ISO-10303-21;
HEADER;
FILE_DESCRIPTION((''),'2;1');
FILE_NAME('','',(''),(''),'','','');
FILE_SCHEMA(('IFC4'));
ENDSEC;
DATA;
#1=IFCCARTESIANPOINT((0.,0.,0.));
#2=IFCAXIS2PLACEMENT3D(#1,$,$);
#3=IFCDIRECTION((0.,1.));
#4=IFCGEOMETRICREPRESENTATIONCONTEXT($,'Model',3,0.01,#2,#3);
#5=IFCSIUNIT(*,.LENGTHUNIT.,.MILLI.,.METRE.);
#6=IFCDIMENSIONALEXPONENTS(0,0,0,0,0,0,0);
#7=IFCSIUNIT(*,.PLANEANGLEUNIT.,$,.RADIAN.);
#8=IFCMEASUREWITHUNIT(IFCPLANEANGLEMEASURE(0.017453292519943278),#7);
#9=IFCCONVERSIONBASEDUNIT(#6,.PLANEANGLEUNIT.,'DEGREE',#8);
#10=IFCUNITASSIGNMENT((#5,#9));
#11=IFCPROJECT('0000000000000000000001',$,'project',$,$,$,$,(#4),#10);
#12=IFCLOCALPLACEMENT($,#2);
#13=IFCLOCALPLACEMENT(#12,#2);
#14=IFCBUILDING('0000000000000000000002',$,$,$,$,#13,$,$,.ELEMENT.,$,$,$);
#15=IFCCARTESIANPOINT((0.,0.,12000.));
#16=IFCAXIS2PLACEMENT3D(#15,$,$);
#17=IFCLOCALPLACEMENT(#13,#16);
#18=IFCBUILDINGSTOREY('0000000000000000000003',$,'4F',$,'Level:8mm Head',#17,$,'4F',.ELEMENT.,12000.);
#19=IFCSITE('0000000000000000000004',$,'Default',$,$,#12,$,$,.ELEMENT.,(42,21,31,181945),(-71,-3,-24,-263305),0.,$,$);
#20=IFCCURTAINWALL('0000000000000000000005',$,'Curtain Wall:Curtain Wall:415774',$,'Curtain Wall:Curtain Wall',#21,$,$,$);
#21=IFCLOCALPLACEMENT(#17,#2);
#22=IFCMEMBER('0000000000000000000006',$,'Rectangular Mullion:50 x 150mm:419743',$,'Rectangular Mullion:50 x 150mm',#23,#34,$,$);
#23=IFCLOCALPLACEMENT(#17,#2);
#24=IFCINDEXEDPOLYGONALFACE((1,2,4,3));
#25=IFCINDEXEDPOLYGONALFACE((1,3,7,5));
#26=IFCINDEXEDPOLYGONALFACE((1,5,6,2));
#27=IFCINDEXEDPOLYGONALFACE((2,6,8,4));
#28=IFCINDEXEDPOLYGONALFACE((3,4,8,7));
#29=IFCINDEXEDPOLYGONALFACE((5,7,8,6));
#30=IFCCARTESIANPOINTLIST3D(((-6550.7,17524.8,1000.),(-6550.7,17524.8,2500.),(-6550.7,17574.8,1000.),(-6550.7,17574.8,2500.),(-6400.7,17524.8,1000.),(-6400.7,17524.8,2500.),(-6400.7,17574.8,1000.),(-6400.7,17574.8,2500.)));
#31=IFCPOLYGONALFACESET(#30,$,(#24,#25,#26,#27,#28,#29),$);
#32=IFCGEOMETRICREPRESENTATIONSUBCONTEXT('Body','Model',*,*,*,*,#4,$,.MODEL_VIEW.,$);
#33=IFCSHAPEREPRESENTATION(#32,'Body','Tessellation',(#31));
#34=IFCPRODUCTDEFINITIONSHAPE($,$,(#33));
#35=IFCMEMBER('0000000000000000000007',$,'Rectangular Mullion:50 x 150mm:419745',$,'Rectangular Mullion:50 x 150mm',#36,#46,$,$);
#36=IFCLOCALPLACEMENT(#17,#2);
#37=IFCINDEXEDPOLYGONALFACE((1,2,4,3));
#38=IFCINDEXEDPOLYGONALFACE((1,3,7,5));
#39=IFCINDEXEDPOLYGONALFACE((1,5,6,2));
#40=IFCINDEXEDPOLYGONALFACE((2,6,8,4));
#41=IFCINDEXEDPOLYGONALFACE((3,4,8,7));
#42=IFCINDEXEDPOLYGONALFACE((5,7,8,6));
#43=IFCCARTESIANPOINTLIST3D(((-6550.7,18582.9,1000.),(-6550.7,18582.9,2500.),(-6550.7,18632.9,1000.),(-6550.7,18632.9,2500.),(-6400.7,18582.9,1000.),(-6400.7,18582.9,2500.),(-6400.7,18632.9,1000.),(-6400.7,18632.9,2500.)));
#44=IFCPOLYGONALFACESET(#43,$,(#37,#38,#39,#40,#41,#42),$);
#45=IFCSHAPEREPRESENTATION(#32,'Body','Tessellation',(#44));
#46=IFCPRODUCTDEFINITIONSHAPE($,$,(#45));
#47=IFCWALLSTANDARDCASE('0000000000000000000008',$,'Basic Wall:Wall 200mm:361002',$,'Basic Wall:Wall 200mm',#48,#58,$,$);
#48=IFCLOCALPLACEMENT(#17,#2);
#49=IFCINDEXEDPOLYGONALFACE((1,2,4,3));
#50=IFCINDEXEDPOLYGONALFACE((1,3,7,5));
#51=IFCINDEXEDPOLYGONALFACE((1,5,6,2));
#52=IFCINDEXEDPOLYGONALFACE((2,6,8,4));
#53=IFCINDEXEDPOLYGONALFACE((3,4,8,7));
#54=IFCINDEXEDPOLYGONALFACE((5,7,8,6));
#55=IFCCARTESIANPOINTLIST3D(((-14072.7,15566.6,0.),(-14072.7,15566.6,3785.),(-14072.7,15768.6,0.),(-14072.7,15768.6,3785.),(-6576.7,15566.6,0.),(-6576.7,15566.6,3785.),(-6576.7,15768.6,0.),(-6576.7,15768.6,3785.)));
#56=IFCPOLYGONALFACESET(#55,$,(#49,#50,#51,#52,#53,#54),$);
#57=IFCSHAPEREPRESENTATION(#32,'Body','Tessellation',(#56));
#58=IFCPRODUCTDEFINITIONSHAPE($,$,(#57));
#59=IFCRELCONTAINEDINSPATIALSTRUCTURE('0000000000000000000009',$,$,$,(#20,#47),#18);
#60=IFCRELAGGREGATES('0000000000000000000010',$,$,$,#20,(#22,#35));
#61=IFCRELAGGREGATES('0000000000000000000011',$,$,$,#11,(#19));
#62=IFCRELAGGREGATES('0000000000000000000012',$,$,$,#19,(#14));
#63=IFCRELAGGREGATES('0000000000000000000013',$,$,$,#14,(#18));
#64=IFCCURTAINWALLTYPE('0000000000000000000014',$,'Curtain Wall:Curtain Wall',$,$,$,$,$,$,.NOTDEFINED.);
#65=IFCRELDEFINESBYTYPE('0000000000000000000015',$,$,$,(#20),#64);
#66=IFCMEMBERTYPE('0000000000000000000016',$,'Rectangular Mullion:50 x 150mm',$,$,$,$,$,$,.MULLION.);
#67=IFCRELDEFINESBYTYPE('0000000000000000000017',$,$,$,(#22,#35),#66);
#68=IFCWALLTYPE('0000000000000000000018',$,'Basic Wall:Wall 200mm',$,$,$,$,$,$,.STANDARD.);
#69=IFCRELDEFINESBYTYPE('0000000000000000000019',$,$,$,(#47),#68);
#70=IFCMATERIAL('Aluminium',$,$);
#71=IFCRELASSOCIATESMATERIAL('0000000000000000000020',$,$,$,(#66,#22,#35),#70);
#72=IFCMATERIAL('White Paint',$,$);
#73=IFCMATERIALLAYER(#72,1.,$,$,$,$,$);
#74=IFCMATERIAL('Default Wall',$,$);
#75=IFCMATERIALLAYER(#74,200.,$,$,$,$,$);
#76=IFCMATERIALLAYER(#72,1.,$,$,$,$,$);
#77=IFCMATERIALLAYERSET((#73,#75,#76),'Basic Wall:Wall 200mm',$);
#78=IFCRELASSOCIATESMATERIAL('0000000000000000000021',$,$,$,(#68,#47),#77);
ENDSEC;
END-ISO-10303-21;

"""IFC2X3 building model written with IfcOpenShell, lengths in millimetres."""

from ifc_helpers import new_model, entity, si_unit, converted_unit, direction, frame, frame_2d, origin, origin_2d_with_axis, place, context, subcontext, project, spatial, polyline, rectangle, extrude, clip, bounded_halfspace, source, transform, mapped, material, layer, layer_set, layer_usage, type_object, type_shapes, element, aggregate, save


model = new_model("IFC2X3")

# Units and contexts
model_context = context("Model", 3, precision=0.01, world=origin(), true_north=direction((0.0, 1.0)))
body_context = subcontext(model_context, "Body", "Model", "MODEL_VIEW")
ifc_project = project(units=[si_unit("LENGTHUNIT", "METRE", prefix="MILLI"), converted_unit("PLANEANGLEUNIT", "DEGREE", entity("IfcPlaneAngleMeasure", 0.017453292519943278), si_unit("PLANEANGLEUNIT", "RADIAN"), dimensions=[0, 0, 0, 0, 0, 0, 0])], contexts=[model_context])

# Site, building, storey
site_placement = place(None, origin())
site = spatial("IfcSite", under=ifc_project, at=site_placement, Name="Default", CompositionType="ELEMENT", RefLatitude=(42, 21, 31, 181945), RefLongitude=(-71, -3, -24, -263305), RefElevation=0.0)
building_placement = place(site_placement, origin())
building = spatial("IfcBuilding", under=site, at=building_placement, CompositionType="ELEMENT")
storey_placement = place(building_placement, frame((0.0, 0.0, 12000.0)))
storey = spatial("IfcBuildingStorey", under=building, at=storey_placement, Name="4F", ObjectType="Level:8mm Head", LongName="4F", CompositionType="ELEMENT", Elevation=12000.0)

# Curtain wall, members
curtain_wall_type = type_object("IfcCurtainWallType", Name="Curtain Wall:Curtain Wall", PredefinedType="NOTDEFINED")
curtain_wall_placement = place(storey_placement, frame((0.0, 0.0, -12000.0)))
curtain_wall = element("IfcCurtainWall", 1, at=curtain_wall_placement, inside=storey, type_object=curtain_wall_type, Name="Curtain Wall:Curtain Wall:415774", ObjectType="Curtain Wall:Curtain Wall")
ifc_material_1 = material(Name="Aluminium")
member_type_1 = type_object("IfcMemberType", Name="Rectangular Mullion:50 x 150mm", PredefinedType="MULLION", material=ifc_material_1)
shared_shape_1 = source(origin(), body_context, "Body", "SweptSolid", [
    extrude(rectangle(XDim=50.0, YDim=150.0, at=origin_2d_with_axis()), frame((0.0, 0.0, -1500.0), z_axis=(0.0, 0.0, 1.0), x_axis=(-1.0, 0.0, 0.0)), (0.0, 0.0, 1.0), 1500.0),
])
type_shapes(member_type_1, [shared_shape_1])
member_1_placement = place(curtain_wall_placement, frame((-6475.7, 17549.8, 13000.0), z_axis=(0.0, 0.0, -1.0), x_axis=(0.0, -1.0, 0.0)))
member_1 = element("IfcMember", 2, at=member_1_placement, type_object=member_type_1, material=ifc_material_1, Name="Rectangular Mullion:50 x 150mm:419743", ObjectType="Rectangular Mullion:50 x 150mm", context=body_context, shape_type="MappedRepresentation", body=[
    mapped(shared_shape_1, transform((0.0, 0.0, 0.0), scale=1.0)),
])
member_2_placement = place(curtain_wall_placement, frame((-6475.7, 18607.9, 13000.0), z_axis=(0.0, 0.0, -1.0), x_axis=(0.0, -1.0, 0.0)))
member_2 = element("IfcMember", 3, at=member_2_placement, type_object=member_type_1, material=ifc_material_1, Name="Rectangular Mullion:50 x 150mm:419745", ObjectType="Rectangular Mullion:50 x 150mm", context=body_context, shape_type="MappedRepresentation", body=[
    mapped(shared_shape_1, transform((0.0, 0.0, 0.0), scale=1.0)),
])
aggregate(curtain_wall, [member_1, member_2])

# Wall
ifc_material_2 = material(Name="White Paint")
ifc_layer_1 = layer(ifc_material_2, 1.0)
ifc_material_3 = material(Name="Default Wall")
ifc_layer_2 = layer(ifc_material_3, 200.0)
ifc_layer_3 = layer(ifc_material_2, 1.0)
ifc_layer_set = layer_set([ifc_layer_1, ifc_layer_2, ifc_layer_3], Name="Basic Wall:Wall 200mm")
ifc_layer_usage = layer_usage(ifc_layer_set, "AXIS2", "NEGATIVE", 101.0)
wall_type = type_object("IfcWallType", Name="Basic Wall:Wall 200mm", PredefinedType="STANDARD", material=ifc_layer_set)
wall_placement = place(storey_placement, frame((-14072.7, 15667.6, 0.0)))
element("IfcWallStandardCase", 4, at=wall_placement, inside=storey, type_object=wall_type, material=ifc_layer_usage, Name="Basic Wall:Wall 200mm:361002", ObjectType="Basic Wall:Wall 200mm", context=body_context, shape_type="Clipping", body=[
    clip(extrude(rectangle(XDim=7496.0, YDim=202.0, at=frame_2d((3748.0, 0.0), x_axis=(-1.0, 0.0))), origin(), (0.0, 0.0, 1.0), 3785.0), bounded_halfspace(frame((0.0, -101.0, 3785.0), z_axis=(0.0, 0.0, -1.0), x_axis=(0.0, -1.0, 0.0)), True, frame((0.0, -101.0, 3785.0), z_axis=(0.0, 0.0, -1.0), x_axis=(0.0, -1.0, 0.0)), polyline([(0.0, 0.0), (-202.0, 0.0), (-202.0, -498.0), (-202.0, -6998.0), (-202.0, -7496.0), (0.0, -7496.0), (0.0, -6998.0), (0.0, -498.0), (0.0, 0.0)]))),
])

save(model, "model.ifc")
